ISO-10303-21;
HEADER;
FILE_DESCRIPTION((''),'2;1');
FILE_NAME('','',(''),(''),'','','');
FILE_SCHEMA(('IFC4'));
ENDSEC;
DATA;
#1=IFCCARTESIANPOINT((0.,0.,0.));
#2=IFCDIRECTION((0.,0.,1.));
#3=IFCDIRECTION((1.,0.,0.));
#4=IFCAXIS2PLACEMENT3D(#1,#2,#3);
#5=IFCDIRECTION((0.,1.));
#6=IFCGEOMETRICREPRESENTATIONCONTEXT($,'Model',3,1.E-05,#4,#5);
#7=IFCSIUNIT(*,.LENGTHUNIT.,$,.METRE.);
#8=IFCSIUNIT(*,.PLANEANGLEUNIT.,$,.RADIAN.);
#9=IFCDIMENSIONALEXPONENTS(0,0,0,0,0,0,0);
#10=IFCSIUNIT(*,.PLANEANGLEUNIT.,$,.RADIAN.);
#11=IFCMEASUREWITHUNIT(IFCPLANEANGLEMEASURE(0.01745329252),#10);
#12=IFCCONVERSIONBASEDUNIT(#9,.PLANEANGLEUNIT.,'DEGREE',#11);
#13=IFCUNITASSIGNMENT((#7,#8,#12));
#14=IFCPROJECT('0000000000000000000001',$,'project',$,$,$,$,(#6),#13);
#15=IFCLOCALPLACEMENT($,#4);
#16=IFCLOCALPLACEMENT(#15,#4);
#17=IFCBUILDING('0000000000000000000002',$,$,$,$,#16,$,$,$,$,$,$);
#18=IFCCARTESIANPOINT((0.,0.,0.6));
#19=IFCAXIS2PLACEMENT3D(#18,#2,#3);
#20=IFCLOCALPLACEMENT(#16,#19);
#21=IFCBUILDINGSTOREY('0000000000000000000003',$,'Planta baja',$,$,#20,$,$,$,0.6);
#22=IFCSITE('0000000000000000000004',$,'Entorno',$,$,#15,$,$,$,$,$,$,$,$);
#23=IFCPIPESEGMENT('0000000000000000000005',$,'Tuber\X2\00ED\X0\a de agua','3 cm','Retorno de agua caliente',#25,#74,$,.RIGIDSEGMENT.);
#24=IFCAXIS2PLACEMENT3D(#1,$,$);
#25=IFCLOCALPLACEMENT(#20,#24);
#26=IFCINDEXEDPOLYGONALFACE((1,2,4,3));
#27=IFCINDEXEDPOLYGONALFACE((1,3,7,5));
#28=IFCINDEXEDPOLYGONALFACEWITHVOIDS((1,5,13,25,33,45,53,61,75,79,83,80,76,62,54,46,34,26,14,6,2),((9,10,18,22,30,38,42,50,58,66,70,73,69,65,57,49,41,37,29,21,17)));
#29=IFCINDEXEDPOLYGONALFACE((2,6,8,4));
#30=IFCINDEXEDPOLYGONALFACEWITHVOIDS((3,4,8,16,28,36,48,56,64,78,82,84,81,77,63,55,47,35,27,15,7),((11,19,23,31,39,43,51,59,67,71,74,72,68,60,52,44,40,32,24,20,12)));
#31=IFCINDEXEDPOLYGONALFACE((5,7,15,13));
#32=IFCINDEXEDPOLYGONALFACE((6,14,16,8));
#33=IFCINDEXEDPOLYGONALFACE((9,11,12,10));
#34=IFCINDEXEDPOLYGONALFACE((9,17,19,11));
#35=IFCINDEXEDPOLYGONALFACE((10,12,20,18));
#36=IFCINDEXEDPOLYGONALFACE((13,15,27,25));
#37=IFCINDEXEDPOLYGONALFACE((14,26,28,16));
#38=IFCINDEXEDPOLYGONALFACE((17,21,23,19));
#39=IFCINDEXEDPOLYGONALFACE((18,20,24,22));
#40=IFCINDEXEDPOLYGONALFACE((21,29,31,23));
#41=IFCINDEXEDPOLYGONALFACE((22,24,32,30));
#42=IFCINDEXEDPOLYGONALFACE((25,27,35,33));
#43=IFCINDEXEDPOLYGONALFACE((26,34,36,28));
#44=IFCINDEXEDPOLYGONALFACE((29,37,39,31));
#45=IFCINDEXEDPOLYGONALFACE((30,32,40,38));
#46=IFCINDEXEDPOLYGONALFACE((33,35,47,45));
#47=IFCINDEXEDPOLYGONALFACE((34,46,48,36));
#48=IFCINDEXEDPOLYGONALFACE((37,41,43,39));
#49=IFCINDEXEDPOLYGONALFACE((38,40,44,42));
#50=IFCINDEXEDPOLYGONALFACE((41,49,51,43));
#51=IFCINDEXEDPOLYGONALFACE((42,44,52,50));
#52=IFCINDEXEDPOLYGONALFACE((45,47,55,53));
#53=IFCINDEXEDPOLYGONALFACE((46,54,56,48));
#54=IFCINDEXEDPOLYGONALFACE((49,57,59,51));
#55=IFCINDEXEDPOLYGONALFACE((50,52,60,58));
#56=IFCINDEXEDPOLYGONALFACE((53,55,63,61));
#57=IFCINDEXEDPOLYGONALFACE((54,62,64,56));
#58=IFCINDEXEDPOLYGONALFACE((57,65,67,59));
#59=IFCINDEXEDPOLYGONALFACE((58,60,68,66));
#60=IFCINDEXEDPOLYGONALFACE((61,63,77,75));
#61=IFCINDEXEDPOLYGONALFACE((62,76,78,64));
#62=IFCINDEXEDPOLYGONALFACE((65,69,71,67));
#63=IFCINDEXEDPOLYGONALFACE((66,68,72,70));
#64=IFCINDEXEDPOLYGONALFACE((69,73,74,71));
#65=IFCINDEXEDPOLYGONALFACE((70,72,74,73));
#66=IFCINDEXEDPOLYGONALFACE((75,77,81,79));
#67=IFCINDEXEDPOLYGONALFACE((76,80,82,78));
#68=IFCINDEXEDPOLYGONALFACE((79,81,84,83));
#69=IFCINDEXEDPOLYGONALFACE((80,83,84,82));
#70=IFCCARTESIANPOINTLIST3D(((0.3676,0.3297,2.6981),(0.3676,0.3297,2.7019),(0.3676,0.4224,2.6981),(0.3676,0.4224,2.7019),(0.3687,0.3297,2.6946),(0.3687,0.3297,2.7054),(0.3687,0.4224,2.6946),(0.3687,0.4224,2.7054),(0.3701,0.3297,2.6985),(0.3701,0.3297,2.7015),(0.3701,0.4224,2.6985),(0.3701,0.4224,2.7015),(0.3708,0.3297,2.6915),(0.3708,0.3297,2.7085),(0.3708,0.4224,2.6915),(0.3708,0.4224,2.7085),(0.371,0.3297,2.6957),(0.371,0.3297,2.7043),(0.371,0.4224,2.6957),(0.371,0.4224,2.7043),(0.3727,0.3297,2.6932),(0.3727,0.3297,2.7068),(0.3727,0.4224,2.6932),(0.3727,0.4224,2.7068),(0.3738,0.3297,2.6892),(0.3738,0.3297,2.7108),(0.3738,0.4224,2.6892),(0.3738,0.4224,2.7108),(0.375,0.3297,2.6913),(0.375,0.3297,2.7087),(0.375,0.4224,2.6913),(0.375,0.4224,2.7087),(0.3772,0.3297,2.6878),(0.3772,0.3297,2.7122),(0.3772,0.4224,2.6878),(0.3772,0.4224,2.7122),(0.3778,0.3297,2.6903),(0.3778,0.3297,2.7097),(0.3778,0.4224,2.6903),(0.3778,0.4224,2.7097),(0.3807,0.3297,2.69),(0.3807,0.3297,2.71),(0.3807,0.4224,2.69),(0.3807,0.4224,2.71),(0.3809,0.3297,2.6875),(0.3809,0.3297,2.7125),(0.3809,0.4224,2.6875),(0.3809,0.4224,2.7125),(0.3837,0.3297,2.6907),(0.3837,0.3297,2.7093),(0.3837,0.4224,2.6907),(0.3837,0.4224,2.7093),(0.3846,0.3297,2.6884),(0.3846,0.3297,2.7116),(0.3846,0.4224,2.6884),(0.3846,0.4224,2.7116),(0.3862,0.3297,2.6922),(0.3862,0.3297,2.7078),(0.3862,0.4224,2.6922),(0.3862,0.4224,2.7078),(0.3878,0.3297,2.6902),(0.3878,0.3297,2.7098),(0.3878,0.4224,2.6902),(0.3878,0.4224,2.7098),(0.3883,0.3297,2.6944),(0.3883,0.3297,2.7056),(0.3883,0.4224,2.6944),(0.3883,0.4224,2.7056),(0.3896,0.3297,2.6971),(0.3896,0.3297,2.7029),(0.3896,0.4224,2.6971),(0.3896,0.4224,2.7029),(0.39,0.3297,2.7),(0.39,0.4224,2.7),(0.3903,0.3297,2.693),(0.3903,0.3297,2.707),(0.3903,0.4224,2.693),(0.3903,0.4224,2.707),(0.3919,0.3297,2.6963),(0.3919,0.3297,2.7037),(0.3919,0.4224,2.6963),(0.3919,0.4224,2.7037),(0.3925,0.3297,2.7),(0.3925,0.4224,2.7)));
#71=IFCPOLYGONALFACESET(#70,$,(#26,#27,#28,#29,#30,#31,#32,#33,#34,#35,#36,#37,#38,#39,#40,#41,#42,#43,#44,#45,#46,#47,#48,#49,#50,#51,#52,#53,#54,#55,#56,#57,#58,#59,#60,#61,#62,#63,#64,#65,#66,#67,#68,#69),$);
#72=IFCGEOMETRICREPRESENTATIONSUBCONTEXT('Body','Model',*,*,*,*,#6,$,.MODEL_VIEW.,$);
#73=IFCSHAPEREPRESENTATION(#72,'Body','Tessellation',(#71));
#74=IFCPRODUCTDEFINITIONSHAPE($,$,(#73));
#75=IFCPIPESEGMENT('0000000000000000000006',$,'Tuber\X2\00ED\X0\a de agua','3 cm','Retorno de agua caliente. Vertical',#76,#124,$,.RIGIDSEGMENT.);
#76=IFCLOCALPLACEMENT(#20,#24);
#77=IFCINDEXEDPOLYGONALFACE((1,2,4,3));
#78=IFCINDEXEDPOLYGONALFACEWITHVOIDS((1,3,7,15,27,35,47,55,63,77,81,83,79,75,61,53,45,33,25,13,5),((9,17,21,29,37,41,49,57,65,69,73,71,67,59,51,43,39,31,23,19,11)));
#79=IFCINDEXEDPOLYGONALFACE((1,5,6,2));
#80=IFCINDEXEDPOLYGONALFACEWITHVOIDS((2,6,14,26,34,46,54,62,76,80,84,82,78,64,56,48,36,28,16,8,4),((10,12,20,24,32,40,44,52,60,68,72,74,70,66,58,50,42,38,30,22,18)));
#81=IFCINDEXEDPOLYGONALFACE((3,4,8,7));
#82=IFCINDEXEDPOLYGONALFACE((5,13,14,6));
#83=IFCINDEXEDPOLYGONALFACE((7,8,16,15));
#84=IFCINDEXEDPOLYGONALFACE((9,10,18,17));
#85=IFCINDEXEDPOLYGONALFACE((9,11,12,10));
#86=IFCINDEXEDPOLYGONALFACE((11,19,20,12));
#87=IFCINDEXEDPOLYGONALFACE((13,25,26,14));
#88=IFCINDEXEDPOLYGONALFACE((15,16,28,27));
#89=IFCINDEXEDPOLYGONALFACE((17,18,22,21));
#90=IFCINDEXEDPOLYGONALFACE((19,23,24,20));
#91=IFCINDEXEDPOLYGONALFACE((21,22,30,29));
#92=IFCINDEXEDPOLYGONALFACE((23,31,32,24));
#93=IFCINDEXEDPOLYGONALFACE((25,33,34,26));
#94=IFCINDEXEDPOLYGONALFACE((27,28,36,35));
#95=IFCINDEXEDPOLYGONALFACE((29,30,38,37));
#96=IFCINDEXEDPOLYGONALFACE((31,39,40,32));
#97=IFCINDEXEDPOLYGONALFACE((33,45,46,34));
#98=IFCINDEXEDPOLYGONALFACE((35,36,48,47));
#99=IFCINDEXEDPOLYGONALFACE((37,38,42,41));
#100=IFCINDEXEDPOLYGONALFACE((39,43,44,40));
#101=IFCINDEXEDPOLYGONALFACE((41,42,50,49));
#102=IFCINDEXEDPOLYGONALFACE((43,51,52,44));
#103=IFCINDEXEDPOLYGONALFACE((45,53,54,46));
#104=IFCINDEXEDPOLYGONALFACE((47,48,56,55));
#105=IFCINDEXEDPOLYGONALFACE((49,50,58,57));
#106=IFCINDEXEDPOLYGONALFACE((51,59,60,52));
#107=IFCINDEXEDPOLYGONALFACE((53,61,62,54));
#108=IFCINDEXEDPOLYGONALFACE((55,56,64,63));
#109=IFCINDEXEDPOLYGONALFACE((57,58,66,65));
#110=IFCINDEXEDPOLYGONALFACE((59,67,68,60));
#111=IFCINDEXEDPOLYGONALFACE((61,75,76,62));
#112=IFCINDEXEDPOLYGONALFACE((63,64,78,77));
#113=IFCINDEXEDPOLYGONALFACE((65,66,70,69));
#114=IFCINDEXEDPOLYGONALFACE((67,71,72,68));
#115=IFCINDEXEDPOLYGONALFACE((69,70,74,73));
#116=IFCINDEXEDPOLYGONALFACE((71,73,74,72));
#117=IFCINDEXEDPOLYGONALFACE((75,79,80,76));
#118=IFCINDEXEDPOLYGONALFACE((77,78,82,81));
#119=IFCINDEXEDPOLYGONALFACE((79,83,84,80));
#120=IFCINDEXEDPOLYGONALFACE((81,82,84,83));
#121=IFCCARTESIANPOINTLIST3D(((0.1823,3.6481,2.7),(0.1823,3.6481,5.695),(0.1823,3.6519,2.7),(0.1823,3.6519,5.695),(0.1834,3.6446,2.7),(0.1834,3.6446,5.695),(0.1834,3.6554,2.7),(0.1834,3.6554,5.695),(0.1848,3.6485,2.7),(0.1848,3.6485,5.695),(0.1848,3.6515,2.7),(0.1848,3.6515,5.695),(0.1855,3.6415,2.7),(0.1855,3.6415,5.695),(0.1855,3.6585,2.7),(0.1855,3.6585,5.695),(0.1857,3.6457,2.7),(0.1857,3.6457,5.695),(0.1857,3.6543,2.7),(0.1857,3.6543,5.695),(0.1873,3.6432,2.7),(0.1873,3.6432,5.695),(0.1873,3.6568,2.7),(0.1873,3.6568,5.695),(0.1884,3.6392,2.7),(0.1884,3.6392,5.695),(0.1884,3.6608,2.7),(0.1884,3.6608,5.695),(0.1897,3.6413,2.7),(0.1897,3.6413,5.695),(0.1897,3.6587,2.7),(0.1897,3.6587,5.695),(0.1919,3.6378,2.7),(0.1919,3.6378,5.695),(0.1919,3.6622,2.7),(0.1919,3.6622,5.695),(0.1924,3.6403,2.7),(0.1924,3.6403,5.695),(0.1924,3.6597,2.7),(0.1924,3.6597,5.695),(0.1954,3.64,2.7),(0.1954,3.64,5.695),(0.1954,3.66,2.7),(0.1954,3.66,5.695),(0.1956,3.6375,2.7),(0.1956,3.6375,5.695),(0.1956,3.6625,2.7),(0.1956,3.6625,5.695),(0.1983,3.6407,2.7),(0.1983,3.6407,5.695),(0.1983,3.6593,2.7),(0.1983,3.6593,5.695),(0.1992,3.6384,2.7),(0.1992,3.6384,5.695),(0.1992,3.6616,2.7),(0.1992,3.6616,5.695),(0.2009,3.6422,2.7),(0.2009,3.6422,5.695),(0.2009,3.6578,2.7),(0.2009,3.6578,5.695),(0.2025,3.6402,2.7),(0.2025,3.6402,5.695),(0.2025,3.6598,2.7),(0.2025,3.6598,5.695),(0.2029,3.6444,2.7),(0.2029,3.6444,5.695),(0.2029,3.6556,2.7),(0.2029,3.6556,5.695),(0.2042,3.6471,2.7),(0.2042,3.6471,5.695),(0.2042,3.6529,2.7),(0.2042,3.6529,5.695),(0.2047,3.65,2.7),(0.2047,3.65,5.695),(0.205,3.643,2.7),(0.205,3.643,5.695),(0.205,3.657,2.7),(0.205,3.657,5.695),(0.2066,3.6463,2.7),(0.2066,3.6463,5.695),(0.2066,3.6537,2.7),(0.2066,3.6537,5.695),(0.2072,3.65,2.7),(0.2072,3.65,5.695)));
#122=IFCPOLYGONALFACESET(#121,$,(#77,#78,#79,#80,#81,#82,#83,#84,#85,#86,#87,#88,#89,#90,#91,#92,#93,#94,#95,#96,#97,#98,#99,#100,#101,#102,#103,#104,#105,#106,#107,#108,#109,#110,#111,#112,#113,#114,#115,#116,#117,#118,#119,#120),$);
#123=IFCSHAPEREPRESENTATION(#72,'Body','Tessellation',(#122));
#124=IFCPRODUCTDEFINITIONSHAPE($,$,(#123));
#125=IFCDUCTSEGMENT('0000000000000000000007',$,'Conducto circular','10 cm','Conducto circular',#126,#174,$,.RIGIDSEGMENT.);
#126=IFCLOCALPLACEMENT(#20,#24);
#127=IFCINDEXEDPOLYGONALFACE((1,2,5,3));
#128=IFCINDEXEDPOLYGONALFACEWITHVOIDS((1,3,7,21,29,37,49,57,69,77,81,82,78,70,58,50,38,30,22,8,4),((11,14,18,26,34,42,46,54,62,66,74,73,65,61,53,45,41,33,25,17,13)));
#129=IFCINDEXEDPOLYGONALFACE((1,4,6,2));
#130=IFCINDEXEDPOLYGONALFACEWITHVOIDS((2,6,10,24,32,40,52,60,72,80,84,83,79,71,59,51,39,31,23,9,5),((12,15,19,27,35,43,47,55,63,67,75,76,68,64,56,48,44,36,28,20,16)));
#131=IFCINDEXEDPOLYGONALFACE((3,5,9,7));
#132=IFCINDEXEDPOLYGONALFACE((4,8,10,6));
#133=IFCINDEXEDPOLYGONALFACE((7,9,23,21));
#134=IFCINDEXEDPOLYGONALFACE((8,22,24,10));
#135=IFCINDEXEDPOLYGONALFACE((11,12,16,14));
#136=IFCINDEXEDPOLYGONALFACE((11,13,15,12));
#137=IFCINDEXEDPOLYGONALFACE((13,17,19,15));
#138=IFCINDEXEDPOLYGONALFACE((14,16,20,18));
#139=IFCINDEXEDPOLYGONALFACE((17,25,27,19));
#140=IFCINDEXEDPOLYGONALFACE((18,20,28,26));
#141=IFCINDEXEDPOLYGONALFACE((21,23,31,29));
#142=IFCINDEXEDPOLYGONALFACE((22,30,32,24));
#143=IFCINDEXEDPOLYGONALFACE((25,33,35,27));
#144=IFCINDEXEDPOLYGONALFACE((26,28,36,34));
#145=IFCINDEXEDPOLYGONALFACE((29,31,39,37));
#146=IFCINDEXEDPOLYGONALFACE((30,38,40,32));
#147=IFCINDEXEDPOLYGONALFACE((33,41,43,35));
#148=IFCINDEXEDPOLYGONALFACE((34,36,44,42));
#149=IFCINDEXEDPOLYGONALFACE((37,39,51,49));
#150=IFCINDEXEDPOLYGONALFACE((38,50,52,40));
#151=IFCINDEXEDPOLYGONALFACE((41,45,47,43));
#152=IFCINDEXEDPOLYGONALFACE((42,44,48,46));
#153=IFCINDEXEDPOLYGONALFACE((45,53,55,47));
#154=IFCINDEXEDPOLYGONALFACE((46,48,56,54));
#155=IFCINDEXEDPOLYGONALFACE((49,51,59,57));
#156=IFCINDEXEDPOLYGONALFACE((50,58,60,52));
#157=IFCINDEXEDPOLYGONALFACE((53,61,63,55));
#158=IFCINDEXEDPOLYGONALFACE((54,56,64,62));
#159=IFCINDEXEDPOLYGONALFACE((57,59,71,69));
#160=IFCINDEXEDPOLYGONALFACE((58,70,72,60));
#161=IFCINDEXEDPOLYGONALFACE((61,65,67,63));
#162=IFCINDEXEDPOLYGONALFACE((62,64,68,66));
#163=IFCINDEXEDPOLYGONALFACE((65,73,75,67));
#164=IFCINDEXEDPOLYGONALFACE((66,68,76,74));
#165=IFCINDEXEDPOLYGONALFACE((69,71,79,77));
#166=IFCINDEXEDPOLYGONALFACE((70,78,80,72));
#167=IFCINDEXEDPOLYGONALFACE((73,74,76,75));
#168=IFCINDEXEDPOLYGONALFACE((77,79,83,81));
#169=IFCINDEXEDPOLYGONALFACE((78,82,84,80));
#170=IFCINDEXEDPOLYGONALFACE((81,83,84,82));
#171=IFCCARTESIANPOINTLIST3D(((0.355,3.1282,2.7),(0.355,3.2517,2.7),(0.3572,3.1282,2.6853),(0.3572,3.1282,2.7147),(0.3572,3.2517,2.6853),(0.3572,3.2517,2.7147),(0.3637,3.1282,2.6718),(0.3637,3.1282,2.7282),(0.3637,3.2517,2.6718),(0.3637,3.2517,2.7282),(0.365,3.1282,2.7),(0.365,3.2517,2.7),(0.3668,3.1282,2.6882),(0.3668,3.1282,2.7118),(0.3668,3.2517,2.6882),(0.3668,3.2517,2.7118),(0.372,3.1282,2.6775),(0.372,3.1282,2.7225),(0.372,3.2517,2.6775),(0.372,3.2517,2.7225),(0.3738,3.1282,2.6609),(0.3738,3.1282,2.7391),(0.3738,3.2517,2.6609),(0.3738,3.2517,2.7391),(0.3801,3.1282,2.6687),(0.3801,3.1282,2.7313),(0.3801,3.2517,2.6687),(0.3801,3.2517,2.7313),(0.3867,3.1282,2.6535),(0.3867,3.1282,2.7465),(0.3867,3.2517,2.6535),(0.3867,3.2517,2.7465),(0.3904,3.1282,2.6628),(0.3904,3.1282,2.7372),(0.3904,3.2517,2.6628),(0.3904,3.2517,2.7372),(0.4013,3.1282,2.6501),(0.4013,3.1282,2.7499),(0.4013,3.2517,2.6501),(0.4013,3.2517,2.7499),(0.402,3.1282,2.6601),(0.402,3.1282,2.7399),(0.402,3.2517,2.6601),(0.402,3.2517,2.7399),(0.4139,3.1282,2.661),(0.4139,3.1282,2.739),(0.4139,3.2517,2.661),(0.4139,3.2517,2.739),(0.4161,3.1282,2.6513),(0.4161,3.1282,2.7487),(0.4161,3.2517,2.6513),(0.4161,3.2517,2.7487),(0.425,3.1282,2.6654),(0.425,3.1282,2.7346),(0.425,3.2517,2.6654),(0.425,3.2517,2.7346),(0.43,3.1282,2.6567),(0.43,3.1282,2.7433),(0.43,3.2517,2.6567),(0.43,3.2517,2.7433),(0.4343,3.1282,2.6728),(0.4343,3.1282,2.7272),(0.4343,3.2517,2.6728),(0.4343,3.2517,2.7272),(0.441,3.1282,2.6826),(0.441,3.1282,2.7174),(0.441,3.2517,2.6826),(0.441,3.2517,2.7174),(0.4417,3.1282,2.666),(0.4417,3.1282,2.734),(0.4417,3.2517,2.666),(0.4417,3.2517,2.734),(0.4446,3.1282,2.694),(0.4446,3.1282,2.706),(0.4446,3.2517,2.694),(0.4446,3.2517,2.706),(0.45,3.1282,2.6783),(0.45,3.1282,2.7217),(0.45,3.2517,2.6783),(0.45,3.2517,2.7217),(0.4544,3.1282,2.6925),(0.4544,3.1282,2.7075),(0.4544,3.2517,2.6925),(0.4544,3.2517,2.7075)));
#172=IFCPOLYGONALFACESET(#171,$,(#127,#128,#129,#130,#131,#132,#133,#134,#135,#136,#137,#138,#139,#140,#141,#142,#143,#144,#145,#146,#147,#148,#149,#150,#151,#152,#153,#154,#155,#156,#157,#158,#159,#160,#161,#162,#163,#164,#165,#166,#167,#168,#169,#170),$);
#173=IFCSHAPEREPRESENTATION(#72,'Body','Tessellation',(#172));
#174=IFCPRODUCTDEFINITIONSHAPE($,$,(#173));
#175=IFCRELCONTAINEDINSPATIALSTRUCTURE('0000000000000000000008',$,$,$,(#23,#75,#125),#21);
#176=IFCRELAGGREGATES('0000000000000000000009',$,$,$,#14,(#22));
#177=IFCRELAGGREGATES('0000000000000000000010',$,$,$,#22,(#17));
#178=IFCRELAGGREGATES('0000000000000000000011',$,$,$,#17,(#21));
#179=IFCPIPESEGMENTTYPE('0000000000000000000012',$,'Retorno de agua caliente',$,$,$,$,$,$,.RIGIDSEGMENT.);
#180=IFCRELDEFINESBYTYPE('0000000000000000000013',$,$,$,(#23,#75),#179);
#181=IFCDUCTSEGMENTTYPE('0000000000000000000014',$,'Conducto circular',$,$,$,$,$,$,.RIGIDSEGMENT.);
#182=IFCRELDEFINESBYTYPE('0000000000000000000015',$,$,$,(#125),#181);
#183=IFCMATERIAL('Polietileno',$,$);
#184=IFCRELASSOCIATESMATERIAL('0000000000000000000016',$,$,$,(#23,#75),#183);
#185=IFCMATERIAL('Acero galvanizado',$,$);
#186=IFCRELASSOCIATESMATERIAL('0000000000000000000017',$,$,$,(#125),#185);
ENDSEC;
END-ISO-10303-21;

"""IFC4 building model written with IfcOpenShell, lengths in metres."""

from ifc_helpers import new_model, entity, si_unit, converted_unit, direction, frame, origin_with_axes, origin_2d_with_axis, place, context, subcontext, project, spatial, hollow_circle, extrude, material, type_object, element, save


model = new_model("IFC4")

# Units and contexts
model_context = context("Model", 3, precision=1e-05, world=origin_with_axes(), true_north=direction((0.0, 1.0)))
body_context = subcontext(model_context, "Body", "Model", "MODEL_VIEW")
ifc_project = project(units=[si_unit("LENGTHUNIT", "METRE"), si_unit("PLANEANGLEUNIT", "RADIAN"), converted_unit("PLANEANGLEUNIT", "DEGREE", entity("IfcPlaneAngleMeasure", 0.01745329252), si_unit("PLANEANGLEUNIT", "RADIAN"), dimensions=[0, 0, 0, 0, 0, 0, 0])], contexts=[model_context])

# Site, building, storey
site_placement = place(None, origin_with_axes())
site = spatial("IfcSite", under=ifc_project, at=site_placement, Name="Entorno")
building_placement = place(site_placement, origin_with_axes())
building = spatial("IfcBuilding", under=site, at=building_placement)
storey_placement = place(building_placement, frame((0.0, 0.0, 0.6), z_axis=(0.0, 0.0, 1.0), x_axis=(1.0, 0.0, 0.0)))
storey = spatial("IfcBuildingStorey", under=building, at=storey_placement, Name="Planta baja", Elevation=0.6)

# Pipe segments
ifc_material_1 = material(Name="Polietileno")
pipe_segment_type_1 = type_object("IfcPipeSegmentType", Name="Retorno de agua caliente", PredefinedType="RIGIDSEGMENT")
pipe_segment_1_placement = place(storey_placement, frame((0.38, 0.4224, 2.7), z_axis=(0.0, -1.0, 0.0), x_axis=(1.0, 0.0, 0.0)))
element("IfcPipeSegment", 1, at=pipe_segment_1_placement, inside=storey, type_object=pipe_segment_type_1, material=ifc_material_1, Name="Tubería de agua", Description="3 cm", ObjectType="Retorno de agua caliente", PredefinedType="RIGIDSEGMENT", context=body_context, shape_type="SweptSolid", body=[
    extrude(hollow_circle(Radius=0.0125, WallThickness=0.0025, at=origin_2d_with_axis()), origin_with_axes(), (0.0, 0.0, 1.0), 0.0928),
])
pipe_segment_2_placement = place(storey_placement, frame((0.1947, 3.65, 2.7), z_axis=(0.0, 0.0, 1.0), x_axis=(1.0, 0.0, 0.0)))
element("IfcPipeSegment", 2, at=pipe_segment_2_placement, inside=storey, type_object=pipe_segment_type_1, material=ifc_material_1, Name="Tubería de agua", Description="3 cm", ObjectType="Retorno de agua caliente. Vertical", PredefinedType="RIGIDSEGMENT", context=body_context, shape_type="SweptSolid", body=[
    extrude(hollow_circle(Radius=0.0125, WallThickness=0.0025, at=origin_2d_with_axis()), origin_with_axes(), (0.0, 0.0, 1.0), 2.995),
])

# Duct segment
ifc_material_2 = material(Name="Acero galvanizado")
duct_segment_type = type_object("IfcDuctSegmentType", Name="Conducto circular", PredefinedType="RIGIDSEGMENT")
duct_segment_1_placement = place(storey_placement, frame((0.405, 3.1282, 2.7), z_axis=(0.0, 1.0, 0.0), x_axis=(-1.0, 0.0, 0.0)))
element("IfcDuctSegment", 3, at=duct_segment_1_placement, inside=storey, type_object=duct_segment_type, material=ifc_material_2, Name="Conducto circular", Description="10 cm", ObjectType="Conducto circular", PredefinedType="RIGIDSEGMENT", context=body_context, shape_type="SweptSolid", body=[
    extrude(hollow_circle(Radius=0.05, WallThickness=0.01, at=origin_2d_with_axis()), origin_with_axes(), (0.0, 0.0, 1.0), 0.1234),
])

save(model, "model.ifc")
